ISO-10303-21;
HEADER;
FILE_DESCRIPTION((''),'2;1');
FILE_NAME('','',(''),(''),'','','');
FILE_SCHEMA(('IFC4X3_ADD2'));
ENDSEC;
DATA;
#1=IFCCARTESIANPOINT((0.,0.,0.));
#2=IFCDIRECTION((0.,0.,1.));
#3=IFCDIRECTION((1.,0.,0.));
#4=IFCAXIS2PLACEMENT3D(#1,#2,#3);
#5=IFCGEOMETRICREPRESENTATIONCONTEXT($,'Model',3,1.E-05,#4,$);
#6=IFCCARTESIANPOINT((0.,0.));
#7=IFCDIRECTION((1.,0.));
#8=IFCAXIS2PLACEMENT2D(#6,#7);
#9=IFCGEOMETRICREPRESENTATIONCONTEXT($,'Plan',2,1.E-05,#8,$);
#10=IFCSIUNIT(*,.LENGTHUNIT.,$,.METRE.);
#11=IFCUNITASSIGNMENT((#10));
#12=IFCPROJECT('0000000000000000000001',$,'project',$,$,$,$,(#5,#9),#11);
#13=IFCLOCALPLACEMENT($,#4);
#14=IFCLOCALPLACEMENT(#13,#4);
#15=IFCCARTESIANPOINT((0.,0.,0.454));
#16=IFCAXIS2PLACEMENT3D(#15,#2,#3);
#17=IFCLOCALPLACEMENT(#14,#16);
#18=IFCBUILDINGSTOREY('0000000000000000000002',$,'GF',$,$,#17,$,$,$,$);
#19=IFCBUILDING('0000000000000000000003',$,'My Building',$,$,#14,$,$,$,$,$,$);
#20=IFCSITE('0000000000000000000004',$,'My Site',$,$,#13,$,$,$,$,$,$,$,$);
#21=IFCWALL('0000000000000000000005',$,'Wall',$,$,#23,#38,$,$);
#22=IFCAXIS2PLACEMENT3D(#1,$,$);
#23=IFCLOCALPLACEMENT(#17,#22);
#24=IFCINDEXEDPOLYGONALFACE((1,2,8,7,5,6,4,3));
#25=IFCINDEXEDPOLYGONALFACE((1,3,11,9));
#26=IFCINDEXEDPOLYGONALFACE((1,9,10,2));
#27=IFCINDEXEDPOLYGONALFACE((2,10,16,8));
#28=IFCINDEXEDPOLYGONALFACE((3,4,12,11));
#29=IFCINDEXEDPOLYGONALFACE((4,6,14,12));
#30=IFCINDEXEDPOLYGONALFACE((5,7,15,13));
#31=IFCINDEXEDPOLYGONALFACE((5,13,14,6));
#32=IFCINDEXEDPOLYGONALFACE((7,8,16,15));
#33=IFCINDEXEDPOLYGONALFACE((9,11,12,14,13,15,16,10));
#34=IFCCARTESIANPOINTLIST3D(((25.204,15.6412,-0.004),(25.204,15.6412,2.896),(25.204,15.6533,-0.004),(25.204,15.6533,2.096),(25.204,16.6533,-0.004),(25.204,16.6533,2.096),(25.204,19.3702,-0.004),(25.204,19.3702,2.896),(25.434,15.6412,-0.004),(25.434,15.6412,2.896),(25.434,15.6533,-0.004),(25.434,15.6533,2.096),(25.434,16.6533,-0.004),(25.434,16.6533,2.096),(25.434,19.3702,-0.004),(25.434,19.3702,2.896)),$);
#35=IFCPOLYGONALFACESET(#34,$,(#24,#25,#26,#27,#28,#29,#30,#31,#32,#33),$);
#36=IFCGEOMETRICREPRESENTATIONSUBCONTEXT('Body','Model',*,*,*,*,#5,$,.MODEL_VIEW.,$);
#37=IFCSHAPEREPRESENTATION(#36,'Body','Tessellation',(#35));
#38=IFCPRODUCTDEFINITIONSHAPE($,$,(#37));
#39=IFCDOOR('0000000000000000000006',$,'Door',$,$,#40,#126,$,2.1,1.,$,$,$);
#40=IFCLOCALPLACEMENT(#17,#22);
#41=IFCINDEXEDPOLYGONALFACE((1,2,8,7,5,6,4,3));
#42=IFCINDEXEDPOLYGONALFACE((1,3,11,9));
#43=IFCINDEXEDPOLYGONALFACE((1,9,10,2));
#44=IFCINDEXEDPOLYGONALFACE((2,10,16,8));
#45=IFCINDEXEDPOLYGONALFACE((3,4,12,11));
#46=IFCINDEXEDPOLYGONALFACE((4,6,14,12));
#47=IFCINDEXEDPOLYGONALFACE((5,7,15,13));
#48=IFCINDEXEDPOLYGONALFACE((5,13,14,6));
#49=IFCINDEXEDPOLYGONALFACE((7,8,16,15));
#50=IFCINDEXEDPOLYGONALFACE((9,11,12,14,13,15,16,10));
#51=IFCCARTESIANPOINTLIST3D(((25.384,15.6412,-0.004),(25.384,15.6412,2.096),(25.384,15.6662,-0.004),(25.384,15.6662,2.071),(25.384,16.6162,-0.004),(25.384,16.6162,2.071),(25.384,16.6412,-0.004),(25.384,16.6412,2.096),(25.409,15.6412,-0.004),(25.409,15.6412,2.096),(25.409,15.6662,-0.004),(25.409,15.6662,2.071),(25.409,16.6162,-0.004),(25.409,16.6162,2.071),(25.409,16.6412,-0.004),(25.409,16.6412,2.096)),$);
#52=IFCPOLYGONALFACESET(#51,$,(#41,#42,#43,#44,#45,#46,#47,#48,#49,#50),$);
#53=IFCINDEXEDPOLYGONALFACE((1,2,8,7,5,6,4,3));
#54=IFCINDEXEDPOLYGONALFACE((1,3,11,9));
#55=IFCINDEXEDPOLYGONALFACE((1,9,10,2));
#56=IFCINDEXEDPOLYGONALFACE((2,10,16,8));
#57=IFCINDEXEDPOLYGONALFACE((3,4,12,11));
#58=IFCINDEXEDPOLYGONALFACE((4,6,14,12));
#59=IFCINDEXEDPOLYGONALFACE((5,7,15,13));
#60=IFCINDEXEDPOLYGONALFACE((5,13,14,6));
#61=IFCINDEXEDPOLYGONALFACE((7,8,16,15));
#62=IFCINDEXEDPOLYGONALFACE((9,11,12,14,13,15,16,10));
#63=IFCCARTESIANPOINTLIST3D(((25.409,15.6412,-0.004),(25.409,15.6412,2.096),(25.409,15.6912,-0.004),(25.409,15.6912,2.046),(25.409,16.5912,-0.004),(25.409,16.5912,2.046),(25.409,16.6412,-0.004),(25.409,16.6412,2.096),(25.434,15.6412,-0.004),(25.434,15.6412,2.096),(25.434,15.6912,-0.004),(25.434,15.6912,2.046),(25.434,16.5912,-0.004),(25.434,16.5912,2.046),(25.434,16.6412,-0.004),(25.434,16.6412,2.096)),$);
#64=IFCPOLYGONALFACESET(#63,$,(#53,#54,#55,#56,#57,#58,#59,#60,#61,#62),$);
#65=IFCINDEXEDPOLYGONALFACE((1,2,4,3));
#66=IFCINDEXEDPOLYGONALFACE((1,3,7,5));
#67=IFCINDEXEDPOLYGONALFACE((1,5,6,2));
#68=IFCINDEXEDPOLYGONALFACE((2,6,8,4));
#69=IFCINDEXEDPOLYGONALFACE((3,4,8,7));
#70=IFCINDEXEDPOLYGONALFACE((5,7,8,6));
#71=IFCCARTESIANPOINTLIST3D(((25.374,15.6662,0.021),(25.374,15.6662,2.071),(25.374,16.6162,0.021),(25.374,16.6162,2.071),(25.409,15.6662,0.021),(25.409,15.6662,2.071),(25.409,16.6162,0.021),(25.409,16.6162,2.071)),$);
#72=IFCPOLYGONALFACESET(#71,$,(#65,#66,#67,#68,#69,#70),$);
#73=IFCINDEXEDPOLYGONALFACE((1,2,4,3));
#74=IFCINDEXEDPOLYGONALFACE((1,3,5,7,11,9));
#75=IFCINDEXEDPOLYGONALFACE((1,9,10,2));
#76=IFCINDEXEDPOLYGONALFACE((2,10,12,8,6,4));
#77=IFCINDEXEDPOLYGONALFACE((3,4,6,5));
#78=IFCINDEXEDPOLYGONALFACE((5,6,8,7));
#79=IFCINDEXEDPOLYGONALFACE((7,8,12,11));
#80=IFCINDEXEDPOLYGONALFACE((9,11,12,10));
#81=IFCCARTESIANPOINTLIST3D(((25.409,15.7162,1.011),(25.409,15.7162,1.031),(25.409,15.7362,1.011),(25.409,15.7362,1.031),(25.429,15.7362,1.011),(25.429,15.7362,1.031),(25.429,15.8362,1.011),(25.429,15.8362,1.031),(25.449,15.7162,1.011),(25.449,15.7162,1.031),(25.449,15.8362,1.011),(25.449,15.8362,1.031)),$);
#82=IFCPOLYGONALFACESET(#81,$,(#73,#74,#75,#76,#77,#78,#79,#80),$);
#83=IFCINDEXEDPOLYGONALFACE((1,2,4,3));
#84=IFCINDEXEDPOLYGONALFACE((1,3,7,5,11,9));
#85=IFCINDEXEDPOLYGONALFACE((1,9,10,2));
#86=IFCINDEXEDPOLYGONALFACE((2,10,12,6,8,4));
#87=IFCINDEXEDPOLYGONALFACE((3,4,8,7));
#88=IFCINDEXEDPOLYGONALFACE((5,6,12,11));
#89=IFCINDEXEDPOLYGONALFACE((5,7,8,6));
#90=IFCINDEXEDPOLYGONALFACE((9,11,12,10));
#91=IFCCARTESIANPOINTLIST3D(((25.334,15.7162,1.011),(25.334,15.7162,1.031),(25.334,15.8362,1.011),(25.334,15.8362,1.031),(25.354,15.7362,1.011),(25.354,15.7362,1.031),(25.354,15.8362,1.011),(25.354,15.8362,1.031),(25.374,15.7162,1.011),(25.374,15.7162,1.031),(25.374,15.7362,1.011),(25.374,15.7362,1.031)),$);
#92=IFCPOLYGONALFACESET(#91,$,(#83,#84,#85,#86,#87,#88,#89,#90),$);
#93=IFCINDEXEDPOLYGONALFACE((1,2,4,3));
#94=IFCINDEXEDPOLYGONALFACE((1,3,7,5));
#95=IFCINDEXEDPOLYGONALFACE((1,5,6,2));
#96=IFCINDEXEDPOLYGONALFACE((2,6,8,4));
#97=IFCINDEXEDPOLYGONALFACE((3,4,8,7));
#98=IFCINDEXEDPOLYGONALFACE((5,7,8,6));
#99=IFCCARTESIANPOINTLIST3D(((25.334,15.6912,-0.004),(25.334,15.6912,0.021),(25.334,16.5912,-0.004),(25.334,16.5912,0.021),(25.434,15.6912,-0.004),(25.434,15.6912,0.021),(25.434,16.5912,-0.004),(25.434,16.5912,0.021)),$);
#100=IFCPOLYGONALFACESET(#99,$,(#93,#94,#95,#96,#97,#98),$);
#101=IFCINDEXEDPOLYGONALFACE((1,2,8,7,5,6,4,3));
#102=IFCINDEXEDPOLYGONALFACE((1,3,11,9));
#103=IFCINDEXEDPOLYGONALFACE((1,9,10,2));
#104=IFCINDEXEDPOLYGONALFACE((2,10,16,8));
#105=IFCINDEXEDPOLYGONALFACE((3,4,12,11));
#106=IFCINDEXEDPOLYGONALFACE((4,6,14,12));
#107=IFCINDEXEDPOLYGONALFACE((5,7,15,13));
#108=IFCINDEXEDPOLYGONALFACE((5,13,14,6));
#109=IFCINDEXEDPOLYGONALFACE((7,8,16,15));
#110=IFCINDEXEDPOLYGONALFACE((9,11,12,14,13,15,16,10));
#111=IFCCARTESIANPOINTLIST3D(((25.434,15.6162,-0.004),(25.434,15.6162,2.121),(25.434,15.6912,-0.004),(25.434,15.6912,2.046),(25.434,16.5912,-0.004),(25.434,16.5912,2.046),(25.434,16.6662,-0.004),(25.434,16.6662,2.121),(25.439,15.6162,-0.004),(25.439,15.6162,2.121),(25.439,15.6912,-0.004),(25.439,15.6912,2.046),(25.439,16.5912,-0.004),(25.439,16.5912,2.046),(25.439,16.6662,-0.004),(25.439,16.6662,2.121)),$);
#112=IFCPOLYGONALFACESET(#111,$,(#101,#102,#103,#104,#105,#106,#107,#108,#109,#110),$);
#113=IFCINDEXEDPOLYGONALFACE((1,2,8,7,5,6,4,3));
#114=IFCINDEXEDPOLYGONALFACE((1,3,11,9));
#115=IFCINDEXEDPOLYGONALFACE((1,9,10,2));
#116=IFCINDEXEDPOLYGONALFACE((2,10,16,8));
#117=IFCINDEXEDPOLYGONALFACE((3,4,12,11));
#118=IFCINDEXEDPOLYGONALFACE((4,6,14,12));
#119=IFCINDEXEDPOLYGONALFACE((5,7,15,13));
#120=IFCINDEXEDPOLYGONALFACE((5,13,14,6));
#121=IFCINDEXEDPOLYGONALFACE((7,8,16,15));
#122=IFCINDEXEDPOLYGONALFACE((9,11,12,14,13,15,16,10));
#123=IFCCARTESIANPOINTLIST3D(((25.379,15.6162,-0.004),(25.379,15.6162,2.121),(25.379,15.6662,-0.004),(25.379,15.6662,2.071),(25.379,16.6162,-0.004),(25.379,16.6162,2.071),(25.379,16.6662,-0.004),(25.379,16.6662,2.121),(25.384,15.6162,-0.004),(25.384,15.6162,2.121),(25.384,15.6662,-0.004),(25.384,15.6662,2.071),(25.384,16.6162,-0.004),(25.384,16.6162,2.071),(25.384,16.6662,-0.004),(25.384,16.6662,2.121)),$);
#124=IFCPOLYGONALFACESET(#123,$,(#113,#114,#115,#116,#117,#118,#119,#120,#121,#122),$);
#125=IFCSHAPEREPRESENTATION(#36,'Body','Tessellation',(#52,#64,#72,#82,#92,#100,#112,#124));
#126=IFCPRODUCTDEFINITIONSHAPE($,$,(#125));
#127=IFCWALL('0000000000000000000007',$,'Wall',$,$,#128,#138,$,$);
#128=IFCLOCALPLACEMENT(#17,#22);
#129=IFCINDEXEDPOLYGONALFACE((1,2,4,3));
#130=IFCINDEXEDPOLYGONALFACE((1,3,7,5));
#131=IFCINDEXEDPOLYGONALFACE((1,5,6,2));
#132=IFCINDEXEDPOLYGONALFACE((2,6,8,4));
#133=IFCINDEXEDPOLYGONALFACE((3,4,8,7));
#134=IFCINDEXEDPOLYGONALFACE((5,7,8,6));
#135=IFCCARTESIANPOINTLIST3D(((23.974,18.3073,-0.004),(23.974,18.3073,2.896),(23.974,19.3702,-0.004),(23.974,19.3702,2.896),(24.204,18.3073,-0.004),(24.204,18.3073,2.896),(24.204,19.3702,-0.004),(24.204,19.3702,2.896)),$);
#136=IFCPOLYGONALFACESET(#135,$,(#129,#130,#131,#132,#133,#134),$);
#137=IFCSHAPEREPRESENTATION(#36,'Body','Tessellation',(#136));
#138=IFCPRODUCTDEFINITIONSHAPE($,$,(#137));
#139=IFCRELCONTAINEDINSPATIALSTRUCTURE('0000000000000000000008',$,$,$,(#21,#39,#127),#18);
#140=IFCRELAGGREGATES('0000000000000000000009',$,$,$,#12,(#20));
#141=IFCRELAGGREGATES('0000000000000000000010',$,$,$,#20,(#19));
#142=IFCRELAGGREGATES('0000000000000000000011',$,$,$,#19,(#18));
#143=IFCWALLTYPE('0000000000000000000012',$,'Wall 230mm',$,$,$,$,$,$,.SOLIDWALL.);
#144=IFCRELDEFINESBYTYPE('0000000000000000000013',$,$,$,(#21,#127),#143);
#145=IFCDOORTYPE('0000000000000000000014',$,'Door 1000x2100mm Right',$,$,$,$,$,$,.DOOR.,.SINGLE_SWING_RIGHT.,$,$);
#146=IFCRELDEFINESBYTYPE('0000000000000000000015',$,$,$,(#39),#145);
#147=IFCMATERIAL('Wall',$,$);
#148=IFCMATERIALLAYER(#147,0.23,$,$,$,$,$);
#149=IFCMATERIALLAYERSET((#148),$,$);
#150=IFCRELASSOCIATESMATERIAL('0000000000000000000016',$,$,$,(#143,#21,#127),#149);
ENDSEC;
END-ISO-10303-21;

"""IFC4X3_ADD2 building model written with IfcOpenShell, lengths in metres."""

from ifc_helpers import new_model, entity, si_unit, frame, origin_with_axes, origin_2d_with_axis, place, context, subcontext, project, spatial, line, indexed_curve, outline, extrude, shape, source, transform, mapped, material, layer, layer_set, layer_usage, type_object, type_shapes, element, fill, save


model = new_model("IFC4X3_ADD2")

# Units and contexts
model_context = context("Model", 3, precision=1e-05, world=origin_with_axes())
plan_context = context("Plan", 2, precision=1e-05, world=origin_2d_with_axis())
body_context_1 = subcontext(model_context, "Body", "Model", "MODEL_VIEW")
body_context_2 = subcontext(plan_context, "Body", "Plan", "PLAN_VIEW")
ifc_project = project(units=[si_unit("LENGTHUNIT", "METRE")], contexts=[model_context, plan_context])

# Site, building, storey
site_placement = place(None, origin_with_axes())
site = spatial("IfcSite", under=ifc_project, at=site_placement, Name="My Site")
building_placement = place(site_placement, origin_with_axes())
building = spatial("IfcBuilding", under=site, at=building_placement, Name="My Building")
storey_placement = place(building_placement, frame((0.0, 0.0, 0.454), z_axis=(0.0, 0.0, 1.0), x_axis=(1.0, 0.0, 0.0)))
storey = spatial("IfcBuildingStorey", under=building, at=storey_placement, Name="GF")

# Shared definitions
ifc_material_1 = material(Name="Wall")

# Shared definitions
ifc_layer_1 = layer(ifc_material_1, 0.23)
ifc_layer_set_1 = layer_set([ifc_layer_1])
wall_type_1 = type_object("IfcWallType", Name="Wall 230mm", PredefinedType="SOLIDWALL", material=ifc_layer_set_1)

# Wall, opening, door
ifc_layer_usage_1 = layer_usage(ifc_layer_set_1, "AXIS2", "POSITIVE", 0.0)
wall_1_placement = place(storey_placement, frame((25.434, 15.6412, -0.004), z_axis=(0.0, 0.0, 1.0), x_axis=(0.000001, 1.0, 0.0)))
wall_1 = element("IfcWall", 1, at=wall_1_placement, inside=storey, type_object=wall_type_1, material=ifc_layer_usage_1, Name="Wall", context=body_context_1, shape_type="SweptSolid", body=[
    extrude(outline(indexed_curve([(0.0, 0.0), (0.0, 0.23), (3.729, 0.23), (3.729, 0.0), (0.0, 0.0)], self_intersect=False)), origin_with_axes(), (0.0, 0.0, 1.0), 2.9),
])
shared_shape_1 = source(origin_with_axes(), body_context_1, "Body", "SweptSolid", [
    extrude(outline(indexed_curve([(0.0, 0.0), (1.0, 0.0), (1.0, 2.1), (0.0, 2.1)], segments=[line(1, 2, 3, 4, 1)])), frame((0.0, -0.6, 0.0), z_axis=(0.0, -1.0, 0.0), x_axis=(1.0, 0.0, 0.0)), (0.0, 0.0, -1.0), 1.2),
])
opening_1_placement = place(wall_1_placement, frame((0.012, 0.0, 0.0), z_axis=(0.0, 0.0, 1.0), x_axis=(1.0, 0.0, 0.0)))
opening_1 = element("IfcOpeningElement", 2, at=opening_1_placement, cuts=wall_1, PredefinedType="OPENING", context=body_context_1, shape_type="MappedRepresentation", body=[
    mapped(shared_shape_1, transform((0.0, 0.0, 0.0), x_axis=(1.0, 0.0, 0.0), y_axis=(0.0, 1.0, 0.0), z_axis=(0.0, 0.0, 1.0), scale=1.0)),
])
door_type_1 = type_object("IfcDoorType", Name="Door 1000x2100mm Right", OperationType="SINGLE_SWING_RIGHT", PredefinedType="DOOR")
shared_shape_2 = source(origin_with_axes(), body_context_1, "Body", "SweptSolid", [
    extrude(outline(indexed_curve([(0.0, 0.0), (0.0, 2.1), (1.0, 2.1), (1.0, 0.0), (0.975, 0.0), (0.975, 2.075), (0.025, 2.075), (0.025, 0.0)], segments=[line(1, 2, 3, 4, 5, 6, 7, 8, 1)])), frame((0.0, 0.025, 0.0), z_axis=(0.0, -1.0, 0.0), x_axis=(1.0, 0.0, 0.0)), (0.0, 0.0, -1.0), 0.025),
    extrude(outline(indexed_curve([(0.0, 0.0), (0.0, 2.1), (1.0, 2.1), (1.0, 0.0), (0.95, 0.0), (0.95, 2.05), (0.05, 2.05), (0.05, 0.0)], segments=[line(1, 2, 3, 4, 5, 6, 7, 8, 1)])), frame((0.0, 0.0, 0.0), z_axis=(0.0, -1.0, 0.0), x_axis=(1.0, 0.0, 0.0)), (0.0, 0.0, -1.0), 0.025),
    extrude(outline(indexed_curve([(0.0, 0.0), (0.95, 0.0), (0.95, 0.035), (0.0, 0.035)], segments=[line(1, 2, 3, 4, 1)])), frame((0.025, 0.025, 0.025), z_axis=(0.0, 0.0, 1.0), x_axis=(1.0, 0.0, 0.0)), (0.0, 0.0, 1.0), 2.05),
    extrude(outline(indexed_curve([(0.0, 0.0), (0.0, -0.04), (0.12, -0.04), (0.12, -0.02), (0.02, -0.02), (0.02, 0.0)], segments=[line(1, 2, 3, 4, 5, 6, 1)])), frame((0.075, 0.025, 1.015), z_axis=(0.0, 0.0, 1.0), x_axis=(1.0, 0.0, 0.0)), (0.0, 0.0, 1.0), 0.02),
    extrude(outline(indexed_curve([(0.0, 0.0), (0.0, 0.04), (0.12, 0.04), (0.12, 0.02), (0.02, 0.02), (0.02, 0.0)], segments=[line(1, 2, 3, 4, 5, 6, 1)])), frame((0.075, 0.06, 1.015), z_axis=(0.0, 0.0, 1.0), x_axis=(1.0, 0.0, 0.0)), (0.0, 0.0, 1.0), 0.02),
    extrude(outline(indexed_curve([(0.0, 0.0), (0.9, 0.0), (0.9, 0.1), (0.0, 0.1)], segments=[line(1, 2, 3, 4, 1)])), frame((0.05, 0.0, 0.0), z_axis=(0.0, 0.0, 1.0), x_axis=(1.0, 0.0, 0.0)), (0.0, 0.0, 1.0), 0.025),
    extrude(outline(indexed_curve([(0.0, 0.0), (0.0, 2.125), (1.05, 2.125), (1.05, 0.0), (0.975, 0.0), (0.975, 2.05), (0.075, 2.05), (0.075, 0.0)], segments=[line(1, 2, 3, 4, 5, 6, 7, 8, 1)])), frame((-0.025, -0.005, 0.0), z_axis=(0.0, -1.0, 0.0), x_axis=(1.0, 0.0, 0.0)), (0.0, 0.0, -1.0), 0.005),
    extrude(outline(indexed_curve([(0.0, 0.0), (0.0, 2.125), (1.05, 2.125), (1.05, 0.0), (1.0, 0.0), (1.0, 2.075), (0.05, 2.075), (0.05, 0.0)], segments=[line(1, 2, 3, 4, 5, 6, 7, 8, 1)])), frame((-0.025, 0.05, 0.0), z_axis=(0.0, -1.0, 0.0), x_axis=(1.0, 0.0, 0.0)), (0.0, 0.0, -1.0), 0.005),
])
shared_shape_3 = source(origin_with_axes(), body_context_2, "Body", "Curve2D", [
    entity("IfcIndexedPolyCurve", entity("IfcCartesianPointList2D", [[0.0, 0.0], [0.0, 0.05], [0.025, 0.05], [0.025, 0.025], [0.05, 0.025], [0.05, 0.0]]), [entity("IfcLineIndex", [1, 2, 3, 4, 5, 6, 1])]),
    entity("IfcIndexedPolyCurve", entity("IfcCartesianPointList2D", [[1.0, 0.0], [1.0, 0.05], [0.975, 0.05], [0.975, 0.025], [0.95, 0.025], [0.95, 0.0]]), [entity("IfcLineIndex", [1, 2, 3, 4, 5, 6, 1])]),
    entity("IfcTrimmedCurve", entity("IfcEllipse", entity("IfcAxis2Placement2D", entity("IfcCartesianPoint", [0.94, 0.05]), entity("IfcDirection", [1.0, 0.0])), 0.915, 0.95), [entity("IfcCartesianPoint", [0.94, 1.0])], [entity("IfcCartesianPoint", [0.025, 0.05])], True, "CARTESIAN"),
    entity("IfcIndexedPolyCurve", entity("IfcCartesianPointList2D", [[0.975, 0.05], [0.94, 0.05], [0.94, 1.0], [0.975, 1.0]]), [entity("IfcLineIndex", [1, 2, 3, 4, 1])]),
])
type_shapes(door_type_1, [shared_shape_2, shared_shape_3])
door_1_placement = place(opening_1_placement, frame((-0.012, 0.0, 0.0), z_axis=(0.0, 0.0, 1.0), x_axis=(1.0, 0.0, 0.0)))
door_1 = element("IfcDoor", 3, at=door_1_placement, inside=storey, type_object=door_type_1, Name="Door", OverallHeight=2.1, OverallWidth=1.0, shapes=[
    shape(body_context_1, "Body", "MappedRepresentation", [mapped(shared_shape_2, transform((0.0, 0.0, 0.0), x_axis=(1.0, 0.0, 0.0), y_axis=(0.0, 1.0, 0.0), z_axis=(0.0, 0.0, 1.0), scale=1.0))]),
    shape(body_context_2, "Body", "MappedRepresentation", [mapped(shared_shape_3, transform((0.0, 0.0, 0.0), x_axis=(1.0, 0.0, 0.0), y_axis=(0.0, 1.0, 0.0), z_axis=(0.0, 0.0, 1.0), scale=1.0))]),
])
fill(opening_1, door_1)

# Wall
ifc_layer_usage_2 = layer_usage(ifc_layer_set_1, "AXIS2", "POSITIVE", 0.0)
wall_2_placement = place(storey_placement, frame((24.204, 18.3073, -0.004), z_axis=(0.0, 0.0, 1.0), x_axis=(0.000001, 1.0, 0.0)))
element("IfcWall", 4, at=wall_2_placement, inside=storey, type_object=wall_type_1, material=ifc_layer_usage_2, Name="Wall", context=body_context_1, shape_type="SweptSolid", body=[
    extrude(outline(indexed_curve([(0.0, 0.0), (0.0, 0.23), (1.0629, 0.23), (1.0629, 0.0), (0.0, 0.0)], self_intersect=False)), origin_with_axes(), (0.0, 0.0, 1.0), 2.9),
])

save(model, "model.ifc")
